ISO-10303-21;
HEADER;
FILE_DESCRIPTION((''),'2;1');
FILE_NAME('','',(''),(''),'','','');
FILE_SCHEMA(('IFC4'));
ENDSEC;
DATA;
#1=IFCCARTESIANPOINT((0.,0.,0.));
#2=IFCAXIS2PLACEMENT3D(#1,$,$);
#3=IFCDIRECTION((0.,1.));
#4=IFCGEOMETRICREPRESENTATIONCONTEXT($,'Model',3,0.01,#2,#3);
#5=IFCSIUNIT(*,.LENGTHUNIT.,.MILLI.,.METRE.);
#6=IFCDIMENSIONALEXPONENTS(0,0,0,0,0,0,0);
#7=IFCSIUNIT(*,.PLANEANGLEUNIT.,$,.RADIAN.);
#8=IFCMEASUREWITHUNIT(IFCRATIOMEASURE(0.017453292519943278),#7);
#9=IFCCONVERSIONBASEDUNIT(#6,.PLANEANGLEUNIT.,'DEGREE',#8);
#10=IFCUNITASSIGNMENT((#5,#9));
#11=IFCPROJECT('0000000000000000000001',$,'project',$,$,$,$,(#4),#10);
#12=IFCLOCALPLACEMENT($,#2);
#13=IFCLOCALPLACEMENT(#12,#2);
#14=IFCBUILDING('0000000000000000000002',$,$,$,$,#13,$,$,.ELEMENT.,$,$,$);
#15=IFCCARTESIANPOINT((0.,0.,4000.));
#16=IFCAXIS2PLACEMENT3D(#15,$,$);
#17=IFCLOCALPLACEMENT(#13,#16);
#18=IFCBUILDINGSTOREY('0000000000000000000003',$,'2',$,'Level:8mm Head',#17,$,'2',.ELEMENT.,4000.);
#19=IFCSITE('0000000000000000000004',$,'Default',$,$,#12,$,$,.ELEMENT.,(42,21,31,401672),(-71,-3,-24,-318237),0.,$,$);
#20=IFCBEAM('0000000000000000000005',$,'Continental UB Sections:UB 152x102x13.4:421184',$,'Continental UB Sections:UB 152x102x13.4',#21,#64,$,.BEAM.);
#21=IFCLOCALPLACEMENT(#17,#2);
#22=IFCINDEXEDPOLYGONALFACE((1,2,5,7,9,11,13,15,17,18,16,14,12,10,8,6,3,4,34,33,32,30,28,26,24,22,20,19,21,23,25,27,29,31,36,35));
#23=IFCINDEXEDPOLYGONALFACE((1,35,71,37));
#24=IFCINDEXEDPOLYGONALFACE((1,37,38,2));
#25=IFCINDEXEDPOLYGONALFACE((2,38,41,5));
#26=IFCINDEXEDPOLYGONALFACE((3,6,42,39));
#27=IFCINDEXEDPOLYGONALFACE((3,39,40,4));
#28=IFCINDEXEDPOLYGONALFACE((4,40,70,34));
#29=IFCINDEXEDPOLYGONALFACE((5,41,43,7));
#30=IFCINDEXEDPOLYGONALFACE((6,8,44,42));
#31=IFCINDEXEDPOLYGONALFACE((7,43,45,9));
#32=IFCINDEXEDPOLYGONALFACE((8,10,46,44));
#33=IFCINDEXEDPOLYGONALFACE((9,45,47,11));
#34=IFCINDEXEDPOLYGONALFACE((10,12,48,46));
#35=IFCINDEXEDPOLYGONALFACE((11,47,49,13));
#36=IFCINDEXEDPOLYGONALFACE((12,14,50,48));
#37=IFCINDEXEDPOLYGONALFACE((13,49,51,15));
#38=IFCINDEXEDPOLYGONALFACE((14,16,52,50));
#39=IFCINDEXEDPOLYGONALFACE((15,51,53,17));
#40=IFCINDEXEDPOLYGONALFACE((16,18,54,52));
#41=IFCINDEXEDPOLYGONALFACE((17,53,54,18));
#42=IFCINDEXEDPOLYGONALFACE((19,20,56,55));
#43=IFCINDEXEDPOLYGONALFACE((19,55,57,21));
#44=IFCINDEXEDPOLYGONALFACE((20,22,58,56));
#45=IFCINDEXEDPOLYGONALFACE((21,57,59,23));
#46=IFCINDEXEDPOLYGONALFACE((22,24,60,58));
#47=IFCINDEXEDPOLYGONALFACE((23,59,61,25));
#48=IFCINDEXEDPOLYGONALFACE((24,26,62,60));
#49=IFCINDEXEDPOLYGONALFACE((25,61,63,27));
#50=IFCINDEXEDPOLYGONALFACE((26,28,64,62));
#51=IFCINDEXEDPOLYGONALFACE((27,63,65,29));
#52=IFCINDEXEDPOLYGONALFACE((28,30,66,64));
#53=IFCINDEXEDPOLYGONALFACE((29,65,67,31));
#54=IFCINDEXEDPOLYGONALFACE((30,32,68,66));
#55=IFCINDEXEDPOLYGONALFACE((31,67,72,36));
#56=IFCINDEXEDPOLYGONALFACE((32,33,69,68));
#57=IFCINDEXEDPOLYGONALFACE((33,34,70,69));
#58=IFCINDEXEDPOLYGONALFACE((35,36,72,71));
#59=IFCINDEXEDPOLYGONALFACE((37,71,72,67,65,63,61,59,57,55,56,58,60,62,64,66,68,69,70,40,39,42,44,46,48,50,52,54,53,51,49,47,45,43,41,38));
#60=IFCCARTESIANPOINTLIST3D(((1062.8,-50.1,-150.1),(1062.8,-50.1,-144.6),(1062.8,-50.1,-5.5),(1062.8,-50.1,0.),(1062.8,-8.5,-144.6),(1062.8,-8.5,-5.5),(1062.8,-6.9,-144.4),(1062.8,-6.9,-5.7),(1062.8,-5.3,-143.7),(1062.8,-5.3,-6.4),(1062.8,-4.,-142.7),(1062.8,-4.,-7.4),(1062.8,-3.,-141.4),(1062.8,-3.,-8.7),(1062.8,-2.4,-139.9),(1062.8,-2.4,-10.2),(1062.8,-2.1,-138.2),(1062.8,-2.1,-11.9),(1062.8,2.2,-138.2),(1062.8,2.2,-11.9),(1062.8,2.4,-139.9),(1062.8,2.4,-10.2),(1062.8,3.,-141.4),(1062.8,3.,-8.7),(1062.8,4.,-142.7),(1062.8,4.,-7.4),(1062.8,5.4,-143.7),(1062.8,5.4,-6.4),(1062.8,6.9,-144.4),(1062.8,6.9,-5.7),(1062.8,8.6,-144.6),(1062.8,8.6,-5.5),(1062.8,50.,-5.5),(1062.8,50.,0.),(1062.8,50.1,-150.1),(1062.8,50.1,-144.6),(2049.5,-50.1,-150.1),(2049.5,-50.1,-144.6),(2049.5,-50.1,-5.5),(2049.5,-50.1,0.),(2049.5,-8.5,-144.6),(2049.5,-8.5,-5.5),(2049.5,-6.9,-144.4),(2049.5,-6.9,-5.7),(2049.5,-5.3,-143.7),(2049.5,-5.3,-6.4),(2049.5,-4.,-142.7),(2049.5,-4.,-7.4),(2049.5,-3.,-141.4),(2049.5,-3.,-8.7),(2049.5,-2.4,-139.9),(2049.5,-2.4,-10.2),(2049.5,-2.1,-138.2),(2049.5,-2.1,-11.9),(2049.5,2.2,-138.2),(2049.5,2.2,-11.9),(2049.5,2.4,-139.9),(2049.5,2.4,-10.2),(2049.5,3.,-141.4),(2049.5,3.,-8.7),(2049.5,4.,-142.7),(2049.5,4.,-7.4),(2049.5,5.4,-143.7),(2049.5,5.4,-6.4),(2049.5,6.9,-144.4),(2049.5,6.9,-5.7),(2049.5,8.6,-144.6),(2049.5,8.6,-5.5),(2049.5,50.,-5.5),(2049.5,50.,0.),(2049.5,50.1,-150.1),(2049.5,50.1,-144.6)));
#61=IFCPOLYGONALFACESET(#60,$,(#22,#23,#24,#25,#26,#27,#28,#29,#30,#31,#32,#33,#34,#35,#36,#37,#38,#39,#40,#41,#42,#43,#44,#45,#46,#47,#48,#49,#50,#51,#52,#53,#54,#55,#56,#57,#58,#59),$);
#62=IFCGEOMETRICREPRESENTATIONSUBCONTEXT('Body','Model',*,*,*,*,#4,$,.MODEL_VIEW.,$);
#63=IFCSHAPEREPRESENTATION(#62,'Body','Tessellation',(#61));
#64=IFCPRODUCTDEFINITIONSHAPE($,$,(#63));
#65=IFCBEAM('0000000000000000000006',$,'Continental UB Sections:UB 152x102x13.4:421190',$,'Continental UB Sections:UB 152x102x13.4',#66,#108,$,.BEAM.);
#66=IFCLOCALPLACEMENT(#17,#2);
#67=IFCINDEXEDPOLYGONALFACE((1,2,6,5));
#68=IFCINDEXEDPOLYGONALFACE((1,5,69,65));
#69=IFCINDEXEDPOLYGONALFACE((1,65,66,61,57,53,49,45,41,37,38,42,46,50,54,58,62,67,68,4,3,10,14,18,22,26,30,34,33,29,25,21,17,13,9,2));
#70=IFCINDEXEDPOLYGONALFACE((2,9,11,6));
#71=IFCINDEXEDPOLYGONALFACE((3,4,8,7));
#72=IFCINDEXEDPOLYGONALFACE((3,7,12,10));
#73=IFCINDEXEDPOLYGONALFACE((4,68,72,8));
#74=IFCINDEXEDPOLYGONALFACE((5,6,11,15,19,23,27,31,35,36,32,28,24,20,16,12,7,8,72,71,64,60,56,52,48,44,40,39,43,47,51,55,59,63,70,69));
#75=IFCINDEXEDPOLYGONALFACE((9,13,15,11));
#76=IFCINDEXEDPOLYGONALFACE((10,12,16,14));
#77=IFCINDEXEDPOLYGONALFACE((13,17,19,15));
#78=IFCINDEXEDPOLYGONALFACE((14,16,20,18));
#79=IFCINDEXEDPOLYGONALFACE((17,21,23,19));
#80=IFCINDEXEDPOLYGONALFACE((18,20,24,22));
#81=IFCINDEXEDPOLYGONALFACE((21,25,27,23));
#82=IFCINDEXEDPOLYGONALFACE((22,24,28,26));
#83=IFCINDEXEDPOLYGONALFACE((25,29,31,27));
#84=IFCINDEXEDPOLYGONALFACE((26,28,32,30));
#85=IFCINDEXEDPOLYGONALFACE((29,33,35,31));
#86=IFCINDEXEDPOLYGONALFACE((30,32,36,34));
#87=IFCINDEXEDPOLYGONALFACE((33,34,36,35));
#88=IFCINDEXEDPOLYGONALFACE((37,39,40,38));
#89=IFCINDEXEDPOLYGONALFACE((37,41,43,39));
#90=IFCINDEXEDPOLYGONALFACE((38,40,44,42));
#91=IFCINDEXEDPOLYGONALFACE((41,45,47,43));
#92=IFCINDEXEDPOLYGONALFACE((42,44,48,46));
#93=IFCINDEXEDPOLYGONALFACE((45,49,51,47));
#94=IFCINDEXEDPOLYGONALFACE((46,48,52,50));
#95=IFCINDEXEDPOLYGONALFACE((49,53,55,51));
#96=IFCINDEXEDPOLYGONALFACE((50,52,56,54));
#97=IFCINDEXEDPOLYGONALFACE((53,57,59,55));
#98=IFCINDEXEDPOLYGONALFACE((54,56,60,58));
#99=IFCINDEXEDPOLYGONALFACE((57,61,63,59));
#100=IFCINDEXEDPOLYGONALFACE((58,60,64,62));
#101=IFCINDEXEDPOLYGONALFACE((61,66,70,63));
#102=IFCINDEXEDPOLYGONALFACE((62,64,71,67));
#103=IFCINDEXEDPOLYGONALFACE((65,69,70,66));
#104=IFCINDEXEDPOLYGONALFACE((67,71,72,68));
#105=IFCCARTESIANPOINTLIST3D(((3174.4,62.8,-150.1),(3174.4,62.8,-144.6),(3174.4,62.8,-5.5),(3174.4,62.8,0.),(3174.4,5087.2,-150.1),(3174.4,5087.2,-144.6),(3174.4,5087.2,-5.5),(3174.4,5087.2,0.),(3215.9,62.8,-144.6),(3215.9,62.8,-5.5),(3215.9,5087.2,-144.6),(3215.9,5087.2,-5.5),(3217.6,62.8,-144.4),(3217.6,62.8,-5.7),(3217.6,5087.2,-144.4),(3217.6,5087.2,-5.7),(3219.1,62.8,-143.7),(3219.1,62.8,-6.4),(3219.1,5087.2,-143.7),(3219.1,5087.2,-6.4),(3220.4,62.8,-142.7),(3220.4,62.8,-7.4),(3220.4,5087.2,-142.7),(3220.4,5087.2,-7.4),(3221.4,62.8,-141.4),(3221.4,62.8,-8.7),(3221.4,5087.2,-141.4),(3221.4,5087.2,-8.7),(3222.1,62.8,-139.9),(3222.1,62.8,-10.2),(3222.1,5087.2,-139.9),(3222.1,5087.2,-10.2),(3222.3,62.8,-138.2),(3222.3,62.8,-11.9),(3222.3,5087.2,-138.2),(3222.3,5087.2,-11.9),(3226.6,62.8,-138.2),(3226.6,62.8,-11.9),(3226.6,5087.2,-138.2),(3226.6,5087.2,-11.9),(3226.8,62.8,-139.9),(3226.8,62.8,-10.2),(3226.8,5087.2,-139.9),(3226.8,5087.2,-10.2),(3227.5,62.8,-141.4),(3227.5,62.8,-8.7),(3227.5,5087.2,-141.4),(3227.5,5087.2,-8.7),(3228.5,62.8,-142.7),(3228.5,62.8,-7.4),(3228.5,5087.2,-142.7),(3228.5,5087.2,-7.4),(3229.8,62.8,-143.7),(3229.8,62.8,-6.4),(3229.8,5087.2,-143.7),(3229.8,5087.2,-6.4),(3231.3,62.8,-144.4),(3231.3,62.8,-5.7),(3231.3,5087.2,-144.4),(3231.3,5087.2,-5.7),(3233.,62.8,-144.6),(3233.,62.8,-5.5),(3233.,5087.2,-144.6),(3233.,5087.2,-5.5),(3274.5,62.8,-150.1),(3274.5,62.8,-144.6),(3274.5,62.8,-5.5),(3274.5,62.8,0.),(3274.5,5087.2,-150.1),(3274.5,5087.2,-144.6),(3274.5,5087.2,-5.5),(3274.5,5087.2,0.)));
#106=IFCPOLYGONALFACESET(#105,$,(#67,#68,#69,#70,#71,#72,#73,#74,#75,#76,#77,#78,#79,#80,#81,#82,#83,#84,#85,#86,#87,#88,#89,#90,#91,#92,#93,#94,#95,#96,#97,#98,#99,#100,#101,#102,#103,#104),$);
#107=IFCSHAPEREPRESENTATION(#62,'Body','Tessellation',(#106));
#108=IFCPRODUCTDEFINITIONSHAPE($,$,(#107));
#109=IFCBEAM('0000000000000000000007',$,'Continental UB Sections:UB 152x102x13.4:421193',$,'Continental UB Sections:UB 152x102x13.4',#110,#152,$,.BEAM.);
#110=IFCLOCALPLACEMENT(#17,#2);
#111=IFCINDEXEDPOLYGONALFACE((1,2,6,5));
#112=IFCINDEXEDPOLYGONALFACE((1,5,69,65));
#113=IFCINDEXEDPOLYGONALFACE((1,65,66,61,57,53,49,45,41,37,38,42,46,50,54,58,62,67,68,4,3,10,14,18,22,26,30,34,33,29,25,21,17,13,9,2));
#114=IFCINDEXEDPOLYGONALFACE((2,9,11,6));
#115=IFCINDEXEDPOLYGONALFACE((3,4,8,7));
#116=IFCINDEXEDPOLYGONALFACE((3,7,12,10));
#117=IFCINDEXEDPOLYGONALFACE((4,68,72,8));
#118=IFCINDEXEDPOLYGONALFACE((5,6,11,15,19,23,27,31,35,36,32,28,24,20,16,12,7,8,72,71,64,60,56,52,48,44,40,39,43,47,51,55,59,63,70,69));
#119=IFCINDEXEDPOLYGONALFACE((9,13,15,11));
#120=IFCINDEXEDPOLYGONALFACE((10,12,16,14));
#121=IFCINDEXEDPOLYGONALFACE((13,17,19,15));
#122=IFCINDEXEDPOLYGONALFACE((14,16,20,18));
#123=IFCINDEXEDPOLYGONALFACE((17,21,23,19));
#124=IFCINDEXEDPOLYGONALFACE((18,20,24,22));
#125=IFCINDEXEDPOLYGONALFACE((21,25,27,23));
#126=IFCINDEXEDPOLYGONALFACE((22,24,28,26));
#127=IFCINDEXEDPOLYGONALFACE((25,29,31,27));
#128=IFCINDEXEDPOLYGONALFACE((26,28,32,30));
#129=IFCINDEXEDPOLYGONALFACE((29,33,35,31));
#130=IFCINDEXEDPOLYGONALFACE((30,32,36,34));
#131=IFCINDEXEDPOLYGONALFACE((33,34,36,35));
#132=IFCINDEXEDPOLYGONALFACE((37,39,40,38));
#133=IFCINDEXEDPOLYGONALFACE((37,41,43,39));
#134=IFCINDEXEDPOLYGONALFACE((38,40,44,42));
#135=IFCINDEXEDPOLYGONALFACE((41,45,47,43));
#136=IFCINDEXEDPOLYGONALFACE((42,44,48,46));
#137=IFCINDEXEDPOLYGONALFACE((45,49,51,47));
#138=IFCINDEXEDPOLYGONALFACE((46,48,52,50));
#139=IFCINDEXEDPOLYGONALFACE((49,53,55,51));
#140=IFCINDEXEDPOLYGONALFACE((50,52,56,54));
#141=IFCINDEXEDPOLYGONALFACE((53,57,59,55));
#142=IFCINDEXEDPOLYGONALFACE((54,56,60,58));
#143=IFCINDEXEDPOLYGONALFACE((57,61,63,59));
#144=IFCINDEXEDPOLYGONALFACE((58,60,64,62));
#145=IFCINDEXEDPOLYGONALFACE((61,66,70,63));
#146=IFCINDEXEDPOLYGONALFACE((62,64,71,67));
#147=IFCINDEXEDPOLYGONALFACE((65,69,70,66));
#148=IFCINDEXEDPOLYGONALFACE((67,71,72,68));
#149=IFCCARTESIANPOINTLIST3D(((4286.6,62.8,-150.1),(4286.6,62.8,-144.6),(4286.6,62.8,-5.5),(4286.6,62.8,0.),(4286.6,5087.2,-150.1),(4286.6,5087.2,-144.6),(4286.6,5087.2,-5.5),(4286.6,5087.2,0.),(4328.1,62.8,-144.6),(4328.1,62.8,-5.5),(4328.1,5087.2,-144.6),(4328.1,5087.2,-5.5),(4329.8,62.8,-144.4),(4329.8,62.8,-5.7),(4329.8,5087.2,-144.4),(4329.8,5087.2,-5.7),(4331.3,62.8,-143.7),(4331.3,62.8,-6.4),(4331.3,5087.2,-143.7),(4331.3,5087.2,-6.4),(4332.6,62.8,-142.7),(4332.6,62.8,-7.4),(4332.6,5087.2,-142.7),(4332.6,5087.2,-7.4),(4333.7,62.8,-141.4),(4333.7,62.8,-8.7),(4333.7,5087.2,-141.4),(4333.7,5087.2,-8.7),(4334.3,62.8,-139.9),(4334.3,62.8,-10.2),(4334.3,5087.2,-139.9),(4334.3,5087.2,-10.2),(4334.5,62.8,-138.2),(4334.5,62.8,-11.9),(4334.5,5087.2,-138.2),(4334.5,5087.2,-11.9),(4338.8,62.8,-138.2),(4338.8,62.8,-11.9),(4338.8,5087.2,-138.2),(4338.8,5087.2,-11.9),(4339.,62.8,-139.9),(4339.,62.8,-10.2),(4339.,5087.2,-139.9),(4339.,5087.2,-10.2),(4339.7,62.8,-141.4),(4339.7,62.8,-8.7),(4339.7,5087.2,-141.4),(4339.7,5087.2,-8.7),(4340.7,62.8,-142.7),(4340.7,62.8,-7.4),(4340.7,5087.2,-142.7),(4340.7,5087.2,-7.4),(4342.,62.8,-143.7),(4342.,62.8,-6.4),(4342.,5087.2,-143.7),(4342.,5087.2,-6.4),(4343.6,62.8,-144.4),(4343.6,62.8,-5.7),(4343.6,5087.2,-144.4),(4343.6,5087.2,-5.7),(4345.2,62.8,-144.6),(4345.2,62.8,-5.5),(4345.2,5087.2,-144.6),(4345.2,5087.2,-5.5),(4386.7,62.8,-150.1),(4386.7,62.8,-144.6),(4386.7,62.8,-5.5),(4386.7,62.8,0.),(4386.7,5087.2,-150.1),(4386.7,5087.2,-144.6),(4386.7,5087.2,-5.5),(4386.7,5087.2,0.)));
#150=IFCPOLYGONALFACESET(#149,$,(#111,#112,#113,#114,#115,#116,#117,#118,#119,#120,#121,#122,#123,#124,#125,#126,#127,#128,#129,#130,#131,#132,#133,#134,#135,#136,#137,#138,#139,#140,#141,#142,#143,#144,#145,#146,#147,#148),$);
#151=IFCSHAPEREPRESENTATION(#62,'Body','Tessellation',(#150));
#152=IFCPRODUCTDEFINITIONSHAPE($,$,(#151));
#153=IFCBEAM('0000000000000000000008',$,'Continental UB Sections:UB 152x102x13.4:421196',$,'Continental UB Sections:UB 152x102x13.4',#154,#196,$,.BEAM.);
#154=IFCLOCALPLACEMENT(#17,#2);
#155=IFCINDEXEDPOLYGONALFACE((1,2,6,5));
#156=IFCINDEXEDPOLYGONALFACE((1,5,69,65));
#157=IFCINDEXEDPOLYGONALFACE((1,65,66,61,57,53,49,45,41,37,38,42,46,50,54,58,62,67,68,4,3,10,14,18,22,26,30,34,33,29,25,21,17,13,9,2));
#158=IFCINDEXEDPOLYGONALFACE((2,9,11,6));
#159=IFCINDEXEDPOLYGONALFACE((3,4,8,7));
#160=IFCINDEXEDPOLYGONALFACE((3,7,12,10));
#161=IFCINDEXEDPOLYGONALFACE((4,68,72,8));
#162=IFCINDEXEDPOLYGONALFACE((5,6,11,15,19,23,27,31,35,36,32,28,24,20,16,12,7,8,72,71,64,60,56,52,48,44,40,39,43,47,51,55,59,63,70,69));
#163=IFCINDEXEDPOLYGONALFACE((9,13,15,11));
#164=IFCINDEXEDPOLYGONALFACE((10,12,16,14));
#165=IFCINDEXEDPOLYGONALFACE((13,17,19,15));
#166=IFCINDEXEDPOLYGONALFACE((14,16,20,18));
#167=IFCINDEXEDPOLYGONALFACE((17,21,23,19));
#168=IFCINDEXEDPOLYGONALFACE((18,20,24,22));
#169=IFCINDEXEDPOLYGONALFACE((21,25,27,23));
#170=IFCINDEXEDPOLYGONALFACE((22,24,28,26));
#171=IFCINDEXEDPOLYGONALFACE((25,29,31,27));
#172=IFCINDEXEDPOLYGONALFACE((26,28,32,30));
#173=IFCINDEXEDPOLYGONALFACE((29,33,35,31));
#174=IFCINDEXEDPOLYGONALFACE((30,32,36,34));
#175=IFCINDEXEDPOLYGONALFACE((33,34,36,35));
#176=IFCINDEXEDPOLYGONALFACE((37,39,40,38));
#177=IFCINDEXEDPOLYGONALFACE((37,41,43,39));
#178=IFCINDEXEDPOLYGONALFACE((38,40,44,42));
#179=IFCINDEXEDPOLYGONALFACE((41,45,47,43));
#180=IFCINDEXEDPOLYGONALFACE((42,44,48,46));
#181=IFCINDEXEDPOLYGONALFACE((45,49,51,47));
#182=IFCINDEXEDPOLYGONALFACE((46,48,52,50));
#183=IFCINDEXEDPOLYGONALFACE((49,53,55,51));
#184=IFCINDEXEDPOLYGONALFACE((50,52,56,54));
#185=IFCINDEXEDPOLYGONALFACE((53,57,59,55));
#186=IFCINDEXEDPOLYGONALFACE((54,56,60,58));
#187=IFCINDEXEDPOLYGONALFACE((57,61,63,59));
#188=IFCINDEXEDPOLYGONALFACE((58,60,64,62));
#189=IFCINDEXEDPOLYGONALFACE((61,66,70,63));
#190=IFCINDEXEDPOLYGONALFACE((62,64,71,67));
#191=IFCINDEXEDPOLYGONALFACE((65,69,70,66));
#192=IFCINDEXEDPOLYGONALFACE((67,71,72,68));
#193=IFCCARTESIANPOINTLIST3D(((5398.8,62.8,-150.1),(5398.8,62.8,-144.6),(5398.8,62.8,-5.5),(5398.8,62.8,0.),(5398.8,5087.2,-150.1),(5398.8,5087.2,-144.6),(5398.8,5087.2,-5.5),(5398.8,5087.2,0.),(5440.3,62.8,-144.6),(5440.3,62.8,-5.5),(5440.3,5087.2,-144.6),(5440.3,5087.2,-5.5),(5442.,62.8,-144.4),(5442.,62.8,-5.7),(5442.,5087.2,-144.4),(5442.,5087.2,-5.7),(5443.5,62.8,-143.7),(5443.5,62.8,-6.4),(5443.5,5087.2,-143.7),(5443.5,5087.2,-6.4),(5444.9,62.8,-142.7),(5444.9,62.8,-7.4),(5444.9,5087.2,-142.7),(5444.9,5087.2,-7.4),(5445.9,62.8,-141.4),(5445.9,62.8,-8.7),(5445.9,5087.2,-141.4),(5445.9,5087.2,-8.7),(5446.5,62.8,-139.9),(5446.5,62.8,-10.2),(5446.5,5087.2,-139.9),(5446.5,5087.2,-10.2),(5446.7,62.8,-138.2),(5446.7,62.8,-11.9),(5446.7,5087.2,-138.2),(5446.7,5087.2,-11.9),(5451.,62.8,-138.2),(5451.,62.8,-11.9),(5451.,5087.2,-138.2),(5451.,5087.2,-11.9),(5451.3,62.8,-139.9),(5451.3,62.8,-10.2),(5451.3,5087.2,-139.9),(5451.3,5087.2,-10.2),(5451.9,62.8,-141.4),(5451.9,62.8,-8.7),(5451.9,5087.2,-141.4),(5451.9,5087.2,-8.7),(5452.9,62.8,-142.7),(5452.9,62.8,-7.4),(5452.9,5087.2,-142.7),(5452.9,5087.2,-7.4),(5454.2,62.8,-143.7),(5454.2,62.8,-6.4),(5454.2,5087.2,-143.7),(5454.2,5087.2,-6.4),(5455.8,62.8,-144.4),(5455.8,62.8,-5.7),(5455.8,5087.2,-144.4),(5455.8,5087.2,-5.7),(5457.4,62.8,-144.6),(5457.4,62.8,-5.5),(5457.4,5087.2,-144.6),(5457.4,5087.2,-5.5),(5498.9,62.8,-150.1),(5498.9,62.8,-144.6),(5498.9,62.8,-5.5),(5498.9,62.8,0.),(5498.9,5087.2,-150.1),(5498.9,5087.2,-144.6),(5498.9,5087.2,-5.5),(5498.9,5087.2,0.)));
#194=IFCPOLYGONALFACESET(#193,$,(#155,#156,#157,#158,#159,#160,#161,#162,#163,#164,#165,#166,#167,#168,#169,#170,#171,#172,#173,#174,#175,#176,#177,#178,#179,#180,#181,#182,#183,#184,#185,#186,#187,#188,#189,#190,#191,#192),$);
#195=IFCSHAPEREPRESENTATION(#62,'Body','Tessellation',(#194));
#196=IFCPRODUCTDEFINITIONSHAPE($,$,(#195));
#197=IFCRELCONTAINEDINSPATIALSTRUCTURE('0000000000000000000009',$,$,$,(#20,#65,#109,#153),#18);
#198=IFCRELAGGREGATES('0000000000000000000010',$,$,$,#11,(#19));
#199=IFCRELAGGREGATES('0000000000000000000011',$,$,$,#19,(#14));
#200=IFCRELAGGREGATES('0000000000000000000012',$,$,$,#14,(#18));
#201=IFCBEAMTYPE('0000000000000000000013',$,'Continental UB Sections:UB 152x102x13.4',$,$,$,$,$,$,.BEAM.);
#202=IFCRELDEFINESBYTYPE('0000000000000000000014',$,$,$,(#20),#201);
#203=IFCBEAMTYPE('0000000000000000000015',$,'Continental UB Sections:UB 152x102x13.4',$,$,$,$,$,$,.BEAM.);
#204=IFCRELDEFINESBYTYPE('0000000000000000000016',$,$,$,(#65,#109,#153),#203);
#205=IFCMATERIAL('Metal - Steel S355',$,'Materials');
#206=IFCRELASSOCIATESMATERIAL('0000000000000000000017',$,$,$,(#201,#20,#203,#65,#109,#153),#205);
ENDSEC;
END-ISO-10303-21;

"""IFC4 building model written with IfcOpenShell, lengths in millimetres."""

from ifc_helpers import new_model, entity, si_unit, converted_unit, direction, frame, origin, place, context, subcontext, project, spatial, line, arc, indexed_curve, outline, extrude, source, transform, mapped, material, type_object, type_shapes, element, save


model = new_model("IFC4")

# Units and contexts
model_context = context("Model", 3, precision=0.01, world=origin(), true_north=direction((0.0, 1.0)))
body_context = subcontext(model_context, "Body", "Model", "MODEL_VIEW")
ifc_project = project(units=[si_unit("LENGTHUNIT", "METRE", prefix="MILLI"), converted_unit("PLANEANGLEUNIT", "DEGREE", entity("IfcRatioMeasure", 0.017453292519943278), si_unit("PLANEANGLEUNIT", "RADIAN"), dimensions=[0, 0, 0, 0, 0, 0, 0])], contexts=[model_context])

# Site, building, storey
site_placement = place(None, origin())
site = spatial("IfcSite", under=ifc_project, at=site_placement, Name="Default", CompositionType="ELEMENT", RefLatitude=(42, 21, 31, 401672), RefLongitude=(-71, -3, -24, -318237), RefElevation=0.0)
building_placement = place(site_placement, origin())
building = spatial("IfcBuilding", under=site, at=building_placement, CompositionType="ELEMENT")
storey_placement = place(building_placement, frame((0.0, 0.0, 4000.0)))
storey = spatial("IfcBuildingStorey", under=building, at=storey_placement, Name="2", ObjectType="Level:8mm Head", LongName="2", CompositionType="ELEMENT", Elevation=4000.0)

# Beams
ifc_material_1 = material(Name="Metal - Steel S355", Category="Materials")
beam_type_1 = type_object("IfcBeamType", Name="Continental UB Sections:UB 152x102x13.4", PredefinedType="BEAM", material=ifc_material_1)
shared_shape_1 = source(origin(), body_context, "Body", "SweptSolid", [
    extrude(outline(indexed_curve([(-75.0, -50.1), (-69.6, -50.1), (-69.6, -8.5), (-67.7, -4.0), (-63.2, -2.1), (63.1, -2.1), (67.7, -4.0), (69.5, -8.5), (69.5, -50.1), (75.1, -50.1), (75.1, 50.1), (69.5, 50.1), (69.5, 8.6), (67.7, 4.0), (63.1, 2.2), (-63.2, 2.2), (-67.7, 4.0), (-69.6, 8.6), (-69.6, 50.0), (-75.0, 50.0)], segments=[line(1, 2, 3), arc(3, 4, 5), line(5, 6), arc(6, 7, 8), line(8, 9, 10, 11, 12, 13), arc(13, 14, 15), line(15, 16), arc(16, 17, 18), line(18, 19, 20, 1)], self_intersect=False)), frame((-493.3, 0.0, 0.0), z_axis=(1.0, 0.0, 0.0), x_axis=(0.0, 0.0, -1.0)), (0.0, 0.0, 1.0), 986.7),
])
type_shapes(beam_type_1, [shared_shape_1])
beam_1_placement = place(storey_placement, frame((1556.1, 0.0, -75.1)))
element("IfcBeam", 1, at=beam_1_placement, inside=storey, type_object=beam_type_1, material=ifc_material_1, Name="Continental UB Sections:UB 152x102x13.4:421184", ObjectType="Continental UB Sections:UB 152x102x13.4", PredefinedType="BEAM", context=body_context, shape_type="MappedRepresentation", body=[
    mapped(shared_shape_1, transform((0.0, 0.0, 0.0), scale=1.0)),
])
beam_type_2 = type_object("IfcBeamType", Name="Continental UB Sections:UB 152x102x13.4", PredefinedType="BEAM", material=ifc_material_1)
shared_shape_2 = source(origin(), body_context, "Body", "SweptSolid", [
    extrude(outline(indexed_curve([(-75.0, -50.1), (-69.6, -50.1), (-69.6, -8.5), (-67.7, -4.0), (-63.2, -2.1), (63.1, -2.1), (67.7, -4.0), (69.5, -8.5), (69.5, -50.1), (75.1, -50.1), (75.1, 50.1), (69.5, 50.1), (69.5, 8.6), (67.7, 4.0), (63.1, 2.2), (-63.2, 2.2), (-67.7, 4.0), (-69.6, 8.6), (-69.6, 50.0), (-75.0, 50.0)], segments=[line(1, 2, 3), arc(3, 4, 5), line(5, 6), arc(6, 7, 8), line(8, 9, 10, 11, 12, 13), arc(13, 14, 15), line(15, 16), arc(16, 17, 18), line(18, 19, 20, 1)], self_intersect=False)), frame((-2487.2, 0.0, 0.0), z_axis=(1.0, 0.0, 0.0), x_axis=(0.0, 0.0, -1.0)), (0.0, 0.0, 1.0), 5024.4),
])
type_shapes(beam_type_2, [shared_shape_2])
for number, where, z_axis, x_axis, name in (
    (2, (3224.4, 2550.0, -75.1), (0.0, 0.0, 1.0), (0.0, 1.0, 0.0), "Continental UB Sections:UB 152x102x13.4:421190"),
    (3, (4336.7, 2550.0, -75.1), (0.0, 0.0, 1.0), (0.0, 1.0, 0.0), "Continental UB Sections:UB 152x102x13.4:421193"),
    (4, (5448.9, 2550.0, -75.1), (0.0, 0.0, 1.0), (0.0, 1.0, 0.0), "Continental UB Sections:UB 152x102x13.4:421196"),
):
    element("IfcBeam", number, at=place(storey_placement, frame(where, z_axis=z_axis, x_axis=x_axis)), inside=storey, type_object=beam_type_2, material=ifc_material_1, Name=name, ObjectType="Continental UB Sections:UB 152x102x13.4", PredefinedType="BEAM", context=body_context, shape_type="MappedRepresentation", body=[
        mapped(shared_shape_2, transform((0.0, 0.0, 0.0), scale=1.0)),
    ])

save(model, "model.ifc")
